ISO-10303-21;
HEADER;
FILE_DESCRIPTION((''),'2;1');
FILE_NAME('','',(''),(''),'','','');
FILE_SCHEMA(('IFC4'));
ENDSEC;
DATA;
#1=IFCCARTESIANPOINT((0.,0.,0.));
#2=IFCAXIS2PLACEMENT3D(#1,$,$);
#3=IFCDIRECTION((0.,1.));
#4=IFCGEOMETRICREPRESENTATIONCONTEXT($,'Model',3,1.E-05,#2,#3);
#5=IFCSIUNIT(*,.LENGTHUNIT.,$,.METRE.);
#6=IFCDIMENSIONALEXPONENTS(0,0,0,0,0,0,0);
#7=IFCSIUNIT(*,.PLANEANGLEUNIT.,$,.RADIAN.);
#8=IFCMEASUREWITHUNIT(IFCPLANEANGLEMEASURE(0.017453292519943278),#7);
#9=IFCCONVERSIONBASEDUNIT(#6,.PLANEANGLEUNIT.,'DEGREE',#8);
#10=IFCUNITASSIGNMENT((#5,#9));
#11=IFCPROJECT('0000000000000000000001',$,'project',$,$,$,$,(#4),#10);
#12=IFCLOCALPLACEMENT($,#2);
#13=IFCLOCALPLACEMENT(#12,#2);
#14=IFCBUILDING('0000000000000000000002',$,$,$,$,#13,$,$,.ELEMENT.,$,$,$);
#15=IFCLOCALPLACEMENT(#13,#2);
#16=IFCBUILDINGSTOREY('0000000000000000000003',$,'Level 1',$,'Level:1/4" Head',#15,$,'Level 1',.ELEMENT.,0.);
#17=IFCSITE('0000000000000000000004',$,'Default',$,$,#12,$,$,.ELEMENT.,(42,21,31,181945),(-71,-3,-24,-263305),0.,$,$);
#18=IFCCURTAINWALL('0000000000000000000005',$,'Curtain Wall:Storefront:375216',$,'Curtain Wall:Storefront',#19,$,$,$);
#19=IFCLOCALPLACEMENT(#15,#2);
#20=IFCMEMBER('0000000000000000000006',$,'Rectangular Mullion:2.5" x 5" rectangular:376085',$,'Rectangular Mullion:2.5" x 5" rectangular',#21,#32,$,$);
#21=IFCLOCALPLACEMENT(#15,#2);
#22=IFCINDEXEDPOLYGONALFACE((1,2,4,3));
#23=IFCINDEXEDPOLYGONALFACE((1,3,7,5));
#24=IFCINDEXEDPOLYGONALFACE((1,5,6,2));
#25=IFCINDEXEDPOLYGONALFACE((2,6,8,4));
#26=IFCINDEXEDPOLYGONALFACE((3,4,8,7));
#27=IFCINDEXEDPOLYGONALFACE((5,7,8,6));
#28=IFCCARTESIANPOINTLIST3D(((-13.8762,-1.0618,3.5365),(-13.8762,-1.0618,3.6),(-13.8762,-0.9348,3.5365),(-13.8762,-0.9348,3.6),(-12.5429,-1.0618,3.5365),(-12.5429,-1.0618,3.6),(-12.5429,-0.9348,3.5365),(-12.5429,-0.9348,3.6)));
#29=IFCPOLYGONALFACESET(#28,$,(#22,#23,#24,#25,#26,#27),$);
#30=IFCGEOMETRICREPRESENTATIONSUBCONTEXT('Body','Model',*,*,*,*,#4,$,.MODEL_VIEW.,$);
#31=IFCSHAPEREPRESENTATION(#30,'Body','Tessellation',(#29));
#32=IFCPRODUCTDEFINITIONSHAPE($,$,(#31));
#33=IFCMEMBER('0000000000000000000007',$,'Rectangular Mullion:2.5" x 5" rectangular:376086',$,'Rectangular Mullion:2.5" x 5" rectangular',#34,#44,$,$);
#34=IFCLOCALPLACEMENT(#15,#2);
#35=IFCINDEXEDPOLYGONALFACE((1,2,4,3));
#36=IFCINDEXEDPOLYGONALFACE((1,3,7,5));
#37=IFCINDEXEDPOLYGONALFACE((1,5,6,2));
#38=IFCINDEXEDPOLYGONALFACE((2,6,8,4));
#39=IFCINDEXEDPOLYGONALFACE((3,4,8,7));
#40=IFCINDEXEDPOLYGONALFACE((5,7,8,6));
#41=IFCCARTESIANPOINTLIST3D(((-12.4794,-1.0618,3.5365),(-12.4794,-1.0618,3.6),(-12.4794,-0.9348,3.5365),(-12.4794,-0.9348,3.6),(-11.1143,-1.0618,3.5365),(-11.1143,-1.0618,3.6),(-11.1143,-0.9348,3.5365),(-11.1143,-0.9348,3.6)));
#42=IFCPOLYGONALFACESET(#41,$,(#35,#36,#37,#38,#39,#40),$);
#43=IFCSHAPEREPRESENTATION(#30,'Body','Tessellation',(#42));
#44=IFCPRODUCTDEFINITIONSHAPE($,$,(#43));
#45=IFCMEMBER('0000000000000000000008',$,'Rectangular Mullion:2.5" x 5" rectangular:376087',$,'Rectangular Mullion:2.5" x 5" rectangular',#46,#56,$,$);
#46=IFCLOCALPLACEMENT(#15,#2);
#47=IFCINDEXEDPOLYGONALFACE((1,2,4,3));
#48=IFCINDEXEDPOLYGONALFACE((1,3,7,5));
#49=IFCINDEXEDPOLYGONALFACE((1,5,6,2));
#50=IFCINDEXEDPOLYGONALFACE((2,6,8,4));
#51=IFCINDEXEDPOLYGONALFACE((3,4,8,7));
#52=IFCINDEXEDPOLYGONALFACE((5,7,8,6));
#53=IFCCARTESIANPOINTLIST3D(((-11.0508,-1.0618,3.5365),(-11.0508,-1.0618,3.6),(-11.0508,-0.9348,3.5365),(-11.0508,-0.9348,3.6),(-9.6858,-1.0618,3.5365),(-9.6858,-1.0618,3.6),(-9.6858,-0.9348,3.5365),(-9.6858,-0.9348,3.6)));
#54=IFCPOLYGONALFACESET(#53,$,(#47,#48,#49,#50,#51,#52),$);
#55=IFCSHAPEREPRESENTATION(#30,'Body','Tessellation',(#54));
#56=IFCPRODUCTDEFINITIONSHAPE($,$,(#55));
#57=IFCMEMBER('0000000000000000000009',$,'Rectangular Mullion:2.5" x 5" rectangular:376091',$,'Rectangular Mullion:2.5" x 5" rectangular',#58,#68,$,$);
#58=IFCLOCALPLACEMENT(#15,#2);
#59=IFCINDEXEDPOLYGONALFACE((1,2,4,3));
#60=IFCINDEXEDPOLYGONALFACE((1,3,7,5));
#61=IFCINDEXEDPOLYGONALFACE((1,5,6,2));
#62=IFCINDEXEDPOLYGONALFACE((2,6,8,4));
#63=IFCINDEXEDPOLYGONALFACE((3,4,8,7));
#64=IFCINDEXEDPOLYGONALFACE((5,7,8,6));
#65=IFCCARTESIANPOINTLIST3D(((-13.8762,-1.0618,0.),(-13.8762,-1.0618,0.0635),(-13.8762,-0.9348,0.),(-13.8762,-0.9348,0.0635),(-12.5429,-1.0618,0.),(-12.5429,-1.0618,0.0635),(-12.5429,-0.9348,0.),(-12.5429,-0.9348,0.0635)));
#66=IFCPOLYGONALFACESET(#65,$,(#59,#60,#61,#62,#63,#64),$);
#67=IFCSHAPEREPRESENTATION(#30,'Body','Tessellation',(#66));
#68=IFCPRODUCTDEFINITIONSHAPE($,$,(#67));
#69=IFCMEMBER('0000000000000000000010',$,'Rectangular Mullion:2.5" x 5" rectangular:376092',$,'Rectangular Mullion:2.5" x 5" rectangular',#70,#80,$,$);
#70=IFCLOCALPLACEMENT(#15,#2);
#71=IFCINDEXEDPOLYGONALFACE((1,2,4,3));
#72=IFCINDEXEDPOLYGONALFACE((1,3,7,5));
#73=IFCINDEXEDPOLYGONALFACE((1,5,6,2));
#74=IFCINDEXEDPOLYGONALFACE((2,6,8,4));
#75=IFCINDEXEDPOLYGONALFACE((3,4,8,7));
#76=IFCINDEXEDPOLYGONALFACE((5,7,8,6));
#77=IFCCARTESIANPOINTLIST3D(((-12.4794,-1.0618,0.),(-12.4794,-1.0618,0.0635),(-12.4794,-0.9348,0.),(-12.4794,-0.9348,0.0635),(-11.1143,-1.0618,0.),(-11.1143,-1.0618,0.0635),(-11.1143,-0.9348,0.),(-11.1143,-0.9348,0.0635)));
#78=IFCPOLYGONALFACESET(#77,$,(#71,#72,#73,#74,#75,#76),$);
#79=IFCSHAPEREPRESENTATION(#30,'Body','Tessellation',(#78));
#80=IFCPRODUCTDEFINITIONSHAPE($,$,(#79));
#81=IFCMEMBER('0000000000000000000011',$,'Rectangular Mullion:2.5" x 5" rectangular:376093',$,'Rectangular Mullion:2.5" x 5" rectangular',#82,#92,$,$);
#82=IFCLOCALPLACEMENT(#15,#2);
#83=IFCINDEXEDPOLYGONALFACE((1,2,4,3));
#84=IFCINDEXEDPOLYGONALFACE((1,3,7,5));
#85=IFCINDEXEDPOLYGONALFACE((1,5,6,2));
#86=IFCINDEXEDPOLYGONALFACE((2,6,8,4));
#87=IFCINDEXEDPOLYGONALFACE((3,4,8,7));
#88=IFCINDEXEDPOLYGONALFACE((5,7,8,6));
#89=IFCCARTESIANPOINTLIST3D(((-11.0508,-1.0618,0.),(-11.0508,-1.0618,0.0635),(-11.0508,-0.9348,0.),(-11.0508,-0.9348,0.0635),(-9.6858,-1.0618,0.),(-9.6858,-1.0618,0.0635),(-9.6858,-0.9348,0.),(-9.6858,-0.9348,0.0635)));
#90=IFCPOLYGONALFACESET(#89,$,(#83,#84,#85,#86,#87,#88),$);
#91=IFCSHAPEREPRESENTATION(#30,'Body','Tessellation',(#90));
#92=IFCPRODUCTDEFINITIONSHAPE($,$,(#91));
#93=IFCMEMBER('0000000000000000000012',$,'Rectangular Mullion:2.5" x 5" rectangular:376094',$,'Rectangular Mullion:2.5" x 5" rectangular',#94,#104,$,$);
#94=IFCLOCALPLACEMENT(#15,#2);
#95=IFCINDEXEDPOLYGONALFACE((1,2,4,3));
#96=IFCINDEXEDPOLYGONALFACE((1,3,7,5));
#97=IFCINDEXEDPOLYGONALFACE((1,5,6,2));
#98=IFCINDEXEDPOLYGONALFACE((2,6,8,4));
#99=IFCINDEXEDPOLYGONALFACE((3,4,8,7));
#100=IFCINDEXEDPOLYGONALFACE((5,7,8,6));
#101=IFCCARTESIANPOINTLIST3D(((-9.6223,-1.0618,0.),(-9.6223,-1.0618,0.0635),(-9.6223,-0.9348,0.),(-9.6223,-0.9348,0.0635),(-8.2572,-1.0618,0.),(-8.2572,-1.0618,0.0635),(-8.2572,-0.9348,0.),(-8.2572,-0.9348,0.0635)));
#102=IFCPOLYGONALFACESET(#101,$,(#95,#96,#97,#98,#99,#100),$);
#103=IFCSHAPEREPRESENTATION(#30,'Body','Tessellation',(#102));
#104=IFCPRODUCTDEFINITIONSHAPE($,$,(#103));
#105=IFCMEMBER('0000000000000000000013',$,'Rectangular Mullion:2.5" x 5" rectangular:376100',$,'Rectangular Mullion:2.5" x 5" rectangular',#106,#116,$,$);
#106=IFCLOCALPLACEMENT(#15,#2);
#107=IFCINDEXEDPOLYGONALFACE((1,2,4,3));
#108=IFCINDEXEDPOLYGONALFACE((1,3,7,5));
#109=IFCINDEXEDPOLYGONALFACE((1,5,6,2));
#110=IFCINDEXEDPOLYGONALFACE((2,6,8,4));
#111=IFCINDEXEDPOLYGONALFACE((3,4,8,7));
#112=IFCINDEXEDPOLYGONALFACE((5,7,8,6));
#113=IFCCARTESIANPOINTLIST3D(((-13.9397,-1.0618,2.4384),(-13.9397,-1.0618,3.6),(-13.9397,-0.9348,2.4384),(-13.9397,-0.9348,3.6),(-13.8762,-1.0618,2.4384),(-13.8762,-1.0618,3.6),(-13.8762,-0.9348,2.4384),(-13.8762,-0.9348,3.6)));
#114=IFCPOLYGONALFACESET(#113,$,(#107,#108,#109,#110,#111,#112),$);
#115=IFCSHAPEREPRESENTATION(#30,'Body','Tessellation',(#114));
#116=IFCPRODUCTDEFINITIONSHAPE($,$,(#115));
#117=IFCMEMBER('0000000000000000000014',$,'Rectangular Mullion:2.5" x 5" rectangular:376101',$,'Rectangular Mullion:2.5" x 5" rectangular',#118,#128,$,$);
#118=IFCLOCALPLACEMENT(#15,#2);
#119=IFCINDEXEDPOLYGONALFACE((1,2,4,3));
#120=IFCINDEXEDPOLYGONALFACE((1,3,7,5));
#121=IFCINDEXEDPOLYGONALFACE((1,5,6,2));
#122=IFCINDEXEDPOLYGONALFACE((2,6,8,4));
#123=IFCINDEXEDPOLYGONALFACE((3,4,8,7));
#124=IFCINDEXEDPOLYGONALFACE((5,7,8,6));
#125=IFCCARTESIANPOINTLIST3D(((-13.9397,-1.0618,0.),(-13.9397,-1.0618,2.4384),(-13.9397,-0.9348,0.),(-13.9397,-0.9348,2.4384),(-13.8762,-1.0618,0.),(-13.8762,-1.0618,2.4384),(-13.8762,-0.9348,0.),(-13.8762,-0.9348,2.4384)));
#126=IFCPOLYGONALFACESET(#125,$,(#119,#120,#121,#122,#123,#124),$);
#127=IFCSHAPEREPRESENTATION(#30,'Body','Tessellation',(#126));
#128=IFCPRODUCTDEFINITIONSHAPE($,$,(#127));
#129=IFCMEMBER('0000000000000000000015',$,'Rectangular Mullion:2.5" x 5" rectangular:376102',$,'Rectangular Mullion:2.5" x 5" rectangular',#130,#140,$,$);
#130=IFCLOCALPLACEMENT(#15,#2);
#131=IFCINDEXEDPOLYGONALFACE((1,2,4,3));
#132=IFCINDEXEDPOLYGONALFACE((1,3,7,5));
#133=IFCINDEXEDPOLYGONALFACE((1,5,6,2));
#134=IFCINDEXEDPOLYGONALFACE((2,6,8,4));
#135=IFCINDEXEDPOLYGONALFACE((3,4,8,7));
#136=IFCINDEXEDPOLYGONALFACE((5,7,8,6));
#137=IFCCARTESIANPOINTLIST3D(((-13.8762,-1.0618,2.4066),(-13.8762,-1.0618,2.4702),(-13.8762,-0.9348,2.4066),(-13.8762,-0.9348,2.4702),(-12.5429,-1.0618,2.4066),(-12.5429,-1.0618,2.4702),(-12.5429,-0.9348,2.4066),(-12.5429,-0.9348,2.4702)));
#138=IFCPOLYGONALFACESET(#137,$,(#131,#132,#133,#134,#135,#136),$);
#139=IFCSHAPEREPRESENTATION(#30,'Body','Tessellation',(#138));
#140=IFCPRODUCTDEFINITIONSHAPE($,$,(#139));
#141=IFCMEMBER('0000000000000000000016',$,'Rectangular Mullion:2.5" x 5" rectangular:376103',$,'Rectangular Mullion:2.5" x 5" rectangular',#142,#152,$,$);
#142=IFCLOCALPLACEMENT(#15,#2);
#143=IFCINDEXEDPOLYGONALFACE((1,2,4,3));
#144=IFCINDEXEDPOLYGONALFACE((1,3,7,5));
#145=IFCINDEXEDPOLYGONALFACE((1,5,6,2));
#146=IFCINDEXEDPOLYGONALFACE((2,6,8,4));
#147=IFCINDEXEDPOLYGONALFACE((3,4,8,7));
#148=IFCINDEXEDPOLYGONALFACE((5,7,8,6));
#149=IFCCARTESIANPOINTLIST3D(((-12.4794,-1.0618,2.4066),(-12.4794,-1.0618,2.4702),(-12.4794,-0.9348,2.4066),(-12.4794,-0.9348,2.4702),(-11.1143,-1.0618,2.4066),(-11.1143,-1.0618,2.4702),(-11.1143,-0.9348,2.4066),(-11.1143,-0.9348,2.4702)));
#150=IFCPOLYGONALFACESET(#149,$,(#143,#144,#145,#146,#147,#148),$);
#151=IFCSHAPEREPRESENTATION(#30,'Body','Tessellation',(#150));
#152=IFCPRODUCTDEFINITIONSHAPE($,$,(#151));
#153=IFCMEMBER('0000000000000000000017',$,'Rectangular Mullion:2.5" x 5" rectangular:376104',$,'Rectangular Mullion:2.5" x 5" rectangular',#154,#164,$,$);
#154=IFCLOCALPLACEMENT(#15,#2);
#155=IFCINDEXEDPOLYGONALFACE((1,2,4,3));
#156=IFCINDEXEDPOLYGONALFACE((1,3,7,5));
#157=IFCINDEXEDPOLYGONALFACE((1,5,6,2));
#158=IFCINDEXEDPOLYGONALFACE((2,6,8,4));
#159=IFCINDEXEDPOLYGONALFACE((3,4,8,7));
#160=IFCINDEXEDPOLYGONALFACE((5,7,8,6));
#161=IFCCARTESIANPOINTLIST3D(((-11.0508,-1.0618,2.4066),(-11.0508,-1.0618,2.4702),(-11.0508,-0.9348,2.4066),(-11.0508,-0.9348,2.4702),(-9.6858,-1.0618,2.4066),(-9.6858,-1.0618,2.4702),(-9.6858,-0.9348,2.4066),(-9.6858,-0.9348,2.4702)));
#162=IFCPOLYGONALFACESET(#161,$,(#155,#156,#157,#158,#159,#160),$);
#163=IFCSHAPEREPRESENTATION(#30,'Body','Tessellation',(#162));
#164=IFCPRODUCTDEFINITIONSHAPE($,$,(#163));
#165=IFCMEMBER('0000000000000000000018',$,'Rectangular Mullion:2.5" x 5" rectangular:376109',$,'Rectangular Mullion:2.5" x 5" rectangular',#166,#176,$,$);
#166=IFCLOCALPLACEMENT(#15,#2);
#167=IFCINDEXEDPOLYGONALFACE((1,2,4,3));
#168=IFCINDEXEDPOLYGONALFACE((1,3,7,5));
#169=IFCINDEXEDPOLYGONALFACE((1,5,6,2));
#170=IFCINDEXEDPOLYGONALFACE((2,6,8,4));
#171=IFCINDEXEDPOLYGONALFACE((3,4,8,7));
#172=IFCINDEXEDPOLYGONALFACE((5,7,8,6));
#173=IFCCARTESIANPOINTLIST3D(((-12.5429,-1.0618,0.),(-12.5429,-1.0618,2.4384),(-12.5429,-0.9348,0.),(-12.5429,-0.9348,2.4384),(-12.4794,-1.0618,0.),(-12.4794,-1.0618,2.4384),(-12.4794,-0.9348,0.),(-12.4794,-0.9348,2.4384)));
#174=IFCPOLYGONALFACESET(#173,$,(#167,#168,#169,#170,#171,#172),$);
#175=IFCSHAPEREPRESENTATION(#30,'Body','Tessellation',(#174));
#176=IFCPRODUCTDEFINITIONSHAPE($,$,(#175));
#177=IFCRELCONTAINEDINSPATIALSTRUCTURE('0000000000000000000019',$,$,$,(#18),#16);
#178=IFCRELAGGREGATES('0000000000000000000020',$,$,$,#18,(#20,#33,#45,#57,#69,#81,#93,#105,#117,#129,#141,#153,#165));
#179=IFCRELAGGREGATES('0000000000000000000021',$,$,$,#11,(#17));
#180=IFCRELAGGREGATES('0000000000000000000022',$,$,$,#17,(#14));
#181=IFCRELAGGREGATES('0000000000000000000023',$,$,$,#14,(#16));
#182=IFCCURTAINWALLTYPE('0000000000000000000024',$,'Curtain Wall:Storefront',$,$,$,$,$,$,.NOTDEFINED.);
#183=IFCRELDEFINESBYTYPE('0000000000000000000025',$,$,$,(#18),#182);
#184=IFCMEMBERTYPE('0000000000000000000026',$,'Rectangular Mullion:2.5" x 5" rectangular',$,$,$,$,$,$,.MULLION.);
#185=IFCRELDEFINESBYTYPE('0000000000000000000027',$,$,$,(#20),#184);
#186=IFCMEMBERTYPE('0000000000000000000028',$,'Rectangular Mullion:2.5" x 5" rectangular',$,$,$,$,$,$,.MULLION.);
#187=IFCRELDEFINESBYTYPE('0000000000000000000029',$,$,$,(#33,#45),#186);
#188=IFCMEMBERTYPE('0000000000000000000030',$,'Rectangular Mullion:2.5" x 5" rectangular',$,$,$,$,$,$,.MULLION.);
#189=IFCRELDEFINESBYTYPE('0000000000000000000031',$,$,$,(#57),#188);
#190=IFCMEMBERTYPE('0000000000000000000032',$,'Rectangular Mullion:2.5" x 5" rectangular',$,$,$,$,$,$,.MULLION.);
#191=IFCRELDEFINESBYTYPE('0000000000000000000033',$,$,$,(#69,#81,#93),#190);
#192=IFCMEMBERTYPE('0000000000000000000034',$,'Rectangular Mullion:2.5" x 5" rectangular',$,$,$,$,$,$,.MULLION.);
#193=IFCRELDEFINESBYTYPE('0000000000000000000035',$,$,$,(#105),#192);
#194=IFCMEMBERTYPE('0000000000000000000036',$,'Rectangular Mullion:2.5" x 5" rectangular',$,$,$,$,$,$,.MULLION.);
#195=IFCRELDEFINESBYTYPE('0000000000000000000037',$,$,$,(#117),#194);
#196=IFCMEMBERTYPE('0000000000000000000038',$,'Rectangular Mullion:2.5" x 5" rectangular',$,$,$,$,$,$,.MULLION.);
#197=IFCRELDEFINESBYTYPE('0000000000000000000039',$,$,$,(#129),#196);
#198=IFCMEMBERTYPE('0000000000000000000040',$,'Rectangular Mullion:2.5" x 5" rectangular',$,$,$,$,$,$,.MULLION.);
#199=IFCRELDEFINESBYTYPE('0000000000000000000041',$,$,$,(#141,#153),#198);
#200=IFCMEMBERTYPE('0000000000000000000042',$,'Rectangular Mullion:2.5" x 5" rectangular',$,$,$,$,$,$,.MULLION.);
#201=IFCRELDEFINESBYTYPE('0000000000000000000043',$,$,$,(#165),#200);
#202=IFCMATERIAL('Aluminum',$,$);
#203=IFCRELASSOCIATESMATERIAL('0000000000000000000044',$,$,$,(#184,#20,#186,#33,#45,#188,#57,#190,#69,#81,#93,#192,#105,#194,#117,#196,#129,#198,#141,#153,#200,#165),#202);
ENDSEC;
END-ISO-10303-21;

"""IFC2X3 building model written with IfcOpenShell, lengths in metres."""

from ifc_helpers import new_model, entity, si_unit, converted_unit, direction, frame, frame_2d, origin, origin_2d_with_axis, place, context, subcontext, project, spatial, rectangle, extrude, source, transform, mapped, material, type_object, type_shapes, element, aggregate, save


model = new_model("IFC2X3")

# Units and contexts
model_context = context("Model", 3, precision=1e-05, world=origin(), true_north=direction((0.0, 1.0)))
body_context = subcontext(model_context, "Body", "Model", "MODEL_VIEW")
ifc_project = project(units=[si_unit("LENGTHUNIT", "METRE"), converted_unit("PLANEANGLEUNIT", "DEGREE", entity("IfcPlaneAngleMeasure", 0.017453292519943278), si_unit("PLANEANGLEUNIT", "RADIAN"), dimensions=[0, 0, 0, 0, 0, 0, 0])], contexts=[model_context])

# Site, building, storey
site_placement = place(None, origin())
site = spatial("IfcSite", under=ifc_project, at=site_placement, Name="Default", CompositionType="ELEMENT", RefLatitude=(42, 21, 31, 181945), RefLongitude=(-71, -3, -24, -263305), RefElevation=0.0)
building_placement = place(site_placement, origin())
building = spatial("IfcBuilding", under=site, at=building_placement, CompositionType="ELEMENT")
storey_placement = place(building_placement, origin())
storey = spatial("IfcBuildingStorey", under=building, at=storey_placement, Name="Level 1", ObjectType="Level:1/4\" Head", LongName="Level 1", CompositionType="ELEMENT", Elevation=0.0)

# Curtain wall, members
curtain_wall_type = type_object("IfcCurtainWallType", Name="Curtain Wall:Storefront", PredefinedType="NOTDEFINED")
curtain_wall_placement = place(storey_placement, origin())
curtain_wall = element("IfcCurtainWall", 1, at=curtain_wall_placement, inside=storey, type_object=curtain_wall_type, Name="Curtain Wall:Storefront:375216", ObjectType="Curtain Wall:Storefront")
ifc_material_1 = material(Name="Aluminum")
member_type_1 = type_object("IfcMemberType", Name="Rectangular Mullion:2.5\" x 5\" rectangular", PredefinedType="MULLION", material=ifc_material_1)
shared_shape_1 = source(origin(), body_context, "Body", "SweptSolid", [
    extrude(rectangle(XDim=0.0635, YDim=0.127, at=frame_2d((0.0, 0.0), x_axis=(1.0, 0.0))), frame((-0.0318, 0.0, -1.3333), z_axis=(0.0, 0.0, 1.0), x_axis=(-1.0, 0.0, 0.0)), (0.0, 0.0, 1.0), 1.3333),
])
type_shapes(member_type_1, [shared_shape_1])
member_1_placement = place(curtain_wall_placement, frame((-12.5429, -0.9983, 3.6), z_axis=(1.0, 0.0, 0.0), x_axis=(0.0, 0.0, 1.0)))
member_1 = element("IfcMember", 2, at=member_1_placement, type_object=member_type_1, material=ifc_material_1, Name="Rectangular Mullion:2.5\" x 5\" rectangular:376085", ObjectType="Rectangular Mullion:2.5\" x 5\" rectangular", context=body_context, shape_type="MappedRepresentation", body=[
    mapped(shared_shape_1, transform((0.0, 0.0, 0.0), scale=1.0)),
])
member_type_2 = type_object("IfcMemberType", Name="Rectangular Mullion:2.5\" x 5\" rectangular", PredefinedType="MULLION", material=ifc_material_1)
shared_shape_2 = source(origin(), body_context, "Body", "SweptSolid", [
    extrude(rectangle(XDim=0.0635, YDim=0.127, at=frame_2d((0.0, 0.0), x_axis=(1.0, 0.0))), frame((-0.0318, 0.0, -1.3651), z_axis=(0.0, 0.0, 1.0), x_axis=(-1.0, 0.0, 0.0)), (0.0, 0.0, 1.0), 1.3651),
])
type_shapes(member_type_2, [shared_shape_2])
member_2_placement = place(curtain_wall_placement, frame((-11.1143, -0.9983, 3.6), z_axis=(1.0, 0.0, 0.0), x_axis=(0.0, 0.0, 1.0)))
member_2 = element("IfcMember", 3, at=member_2_placement, type_object=member_type_2, material=ifc_material_1, Name="Rectangular Mullion:2.5\" x 5\" rectangular:376086", ObjectType="Rectangular Mullion:2.5\" x 5\" rectangular", context=body_context, shape_type="MappedRepresentation", body=[
    mapped(shared_shape_2, transform((0.0, 0.0, 0.0), scale=1.0)),
])
member_3_placement = place(curtain_wall_placement, frame((-9.6858, -0.9983, 3.6), z_axis=(1.0, 0.0, 0.0), x_axis=(0.0, 0.0, 1.0)))
member_3 = element("IfcMember", 4, at=member_3_placement, type_object=member_type_2, material=ifc_material_1, Name="Rectangular Mullion:2.5\" x 5\" rectangular:376087", ObjectType="Rectangular Mullion:2.5\" x 5\" rectangular", context=body_context, shape_type="MappedRepresentation", body=[
    mapped(shared_shape_2, transform((0.0, 0.0, 0.0), scale=1.0)),
])
member_type_3 = type_object("IfcMemberType", Name="Rectangular Mullion:2.5\" x 5\" rectangular", PredefinedType="MULLION", material=ifc_material_1)
shared_shape_3 = source(origin(), body_context, "Body", "SweptSolid", [
    extrude(rectangle(XDim=0.0635, YDim=0.127, at=frame_2d((0.0, 0.0), x_axis=(1.0, 0.0))), frame((-0.0318, 0.0, -1.3333), z_axis=(0.0, 0.0, 1.0), x_axis=(-1.0, 0.0, 0.0)), (0.0, 0.0, 1.0), 1.3333),
])
type_shapes(member_type_3, [shared_shape_3])
member_4_placement = place(curtain_wall_placement, frame((-13.8762, -0.9983, 0.0), z_axis=(-1.0, 0.0, 0.0), x_axis=(0.0, 0.0, -1.0)))
member_4 = element("IfcMember", 5, at=member_4_placement, type_object=member_type_3, material=ifc_material_1, Name="Rectangular Mullion:2.5\" x 5\" rectangular:376091", ObjectType="Rectangular Mullion:2.5\" x 5\" rectangular", context=body_context, shape_type="MappedRepresentation", body=[
    mapped(shared_shape_3, transform((0.0, 0.0, 0.0), scale=1.0)),
])
member_type_4 = type_object("IfcMemberType", Name="Rectangular Mullion:2.5\" x 5\" rectangular", PredefinedType="MULLION", material=ifc_material_1)
shared_shape_4 = source(origin(), body_context, "Body", "SweptSolid", [
    extrude(rectangle(XDim=0.0635, YDim=0.127, at=frame_2d((0.0, 0.0), x_axis=(1.0, 0.0))), frame((-0.0318, 0.0, -1.3651), z_axis=(0.0, 0.0, 1.0), x_axis=(-1.0, 0.0, 0.0)), (0.0, 0.0, 1.0), 1.3651),
])
type_shapes(member_type_4, [shared_shape_4])
member_5_placement = place(curtain_wall_placement, frame((-12.4794, -0.9983, 0.0), z_axis=(-1.0, 0.0, 0.0), x_axis=(0.0, 0.0, -1.0)))
member_5 = element("IfcMember", 6, at=member_5_placement, type_object=member_type_4, material=ifc_material_1, Name="Rectangular Mullion:2.5\" x 5\" rectangular:376092", ObjectType="Rectangular Mullion:2.5\" x 5\" rectangular", context=body_context, shape_type="MappedRepresentation", body=[
    mapped(shared_shape_4, transform((0.0, 0.0, 0.0), scale=1.0)),
])
member_6_placement = place(curtain_wall_placement, frame((-11.0508, -0.9983, 0.0), z_axis=(-1.0, 0.0, 0.0), x_axis=(0.0, 0.0, -1.0)))
member_6 = element("IfcMember", 7, at=member_6_placement, type_object=member_type_4, material=ifc_material_1, Name="Rectangular Mullion:2.5\" x 5\" rectangular:376093", ObjectType="Rectangular Mullion:2.5\" x 5\" rectangular", context=body_context, shape_type="MappedRepresentation", body=[
    mapped(shared_shape_4, transform((0.0, 0.0, 0.0), scale=1.0)),
])
member_7_placement = place(curtain_wall_placement, frame((-9.6223, -0.9983, 0.0), z_axis=(-1.0, 0.0, 0.0), x_axis=(0.0, 0.0, -1.0)))
member_7 = element("IfcMember", 8, at=member_7_placement, type_object=member_type_4, material=ifc_material_1, Name="Rectangular Mullion:2.5\" x 5\" rectangular:376094", ObjectType="Rectangular Mullion:2.5\" x 5\" rectangular", context=body_context, shape_type="MappedRepresentation", body=[
    mapped(shared_shape_4, transform((0.0, 0.0, 0.0), scale=1.0)),
])
member_type_5 = type_object("IfcMemberType", Name="Rectangular Mullion:2.5\" x 5\" rectangular", PredefinedType="MULLION", material=ifc_material_1)
shared_shape_5 = source(origin(), body_context, "Body", "SweptSolid", [
    extrude(rectangle(XDim=0.0635, YDim=0.127, at=frame_2d((0.0, 0.0), x_axis=(1.0, 0.0))), frame((-0.0318, 0.0, -1.1616), z_axis=(0.0, 0.0, 1.0), x_axis=(-1.0, 0.0, 0.0)), (0.0, 0.0, 1.0), 1.1616),
])
type_shapes(member_type_5, [shared_shape_5])
member_8_placement = place(curtain_wall_placement, frame((-13.9397, -0.9983, 3.6), z_axis=(0.0, 0.0, 1.0), x_axis=(-1.0, 0.0, 0.0)))
member_8 = element("IfcMember", 9, at=member_8_placement, type_object=member_type_5, material=ifc_material_1, Name="Rectangular Mullion:2.5\" x 5\" rectangular:376100", ObjectType="Rectangular Mullion:2.5\" x 5\" rectangular", context=body_context, shape_type="MappedRepresentation", body=[
    mapped(shared_shape_5, transform((0.0, 0.0, 0.0), scale=1.0)),
])
member_type_6 = type_object("IfcMemberType", Name="Rectangular Mullion:2.5\" x 5\" rectangular", PredefinedType="MULLION", material=ifc_material_1)
shared_shape_6 = source(origin(), body_context, "Body", "SweptSolid", [
    extrude(rectangle(XDim=0.0635, YDim=0.127, at=frame_2d((0.0, 0.0), x_axis=(1.0, 0.0))), frame((-0.0318, 0.0, -2.4384), z_axis=(0.0, 0.0, 1.0), x_axis=(-1.0, 0.0, 0.0)), (0.0, 0.0, 1.0), 2.4384),
])
type_shapes(member_type_6, [shared_shape_6])
member_9_placement = place(curtain_wall_placement, frame((-13.9397, -0.9983, 2.4384), z_axis=(0.0, 0.0, 1.0), x_axis=(-1.0, 0.0, 0.0)))
member_9 = element("IfcMember", 10, at=member_9_placement, type_object=member_type_6, material=ifc_material_1, Name="Rectangular Mullion:2.5\" x 5\" rectangular:376101", ObjectType="Rectangular Mullion:2.5\" x 5\" rectangular", context=body_context, shape_type="MappedRepresentation", body=[
    mapped(shared_shape_6, transform((0.0, 0.0, 0.0), scale=1.0)),
])
member_type_7 = type_object("IfcMemberType", Name="Rectangular Mullion:2.5\" x 5\" rectangular", PredefinedType="MULLION", material=ifc_material_1)
shared_shape_7 = source(origin(), body_context, "Body", "SweptSolid", [
    extrude(rectangle(XDim=0.0635, YDim=0.127, at=origin_2d_with_axis()), frame((0.0, 0.0, -1.3333), z_axis=(0.0, 0.0, 1.0), x_axis=(-1.0, 0.0, 0.0)), (0.0, 0.0, 1.0), 1.3333),
])
type_shapes(member_type_7, [shared_shape_7])
member_10_placement = place(curtain_wall_placement, frame((-12.5429, -0.9983, 2.4384), z_axis=(1.0, 0.0, 0.0), x_axis=(0.0, 0.0, 1.0)))
member_10 = element("IfcMember", 11, at=member_10_placement, type_object=member_type_7, material=ifc_material_1, Name="Rectangular Mullion:2.5\" x 5\" rectangular:376102", ObjectType="Rectangular Mullion:2.5\" x 5\" rectangular", context=body_context, shape_type="MappedRepresentation", body=[
    mapped(shared_shape_7, transform((0.0, 0.0, 0.0), scale=1.0)),
])
member_type_8 = type_object("IfcMemberType", Name="Rectangular Mullion:2.5\" x 5\" rectangular", PredefinedType="MULLION", material=ifc_material_1)
shared_shape_8 = source(origin(), body_context, "Body", "SweptSolid", [
    extrude(rectangle(XDim=0.0635, YDim=0.127, at=origin_2d_with_axis()), frame((0.0, 0.0, -1.3651), z_axis=(0.0, 0.0, 1.0), x_axis=(-1.0, 0.0, 0.0)), (0.0, 0.0, 1.0), 1.3651),
])
type_shapes(member_type_8, [shared_shape_8])
member_11_placement = place(curtain_wall_placement, frame((-11.1143, -0.9983, 2.4384), z_axis=(1.0, 0.0, 0.0), x_axis=(0.0, 0.0, 1.0)))
member_11 = element("IfcMember", 12, at=member_11_placement, type_object=member_type_8, material=ifc_material_1, Name="Rectangular Mullion:2.5\" x 5\" rectangular:376103", ObjectType="Rectangular Mullion:2.5\" x 5\" rectangular", context=body_context, shape_type="MappedRepresentation", body=[
    mapped(shared_shape_8, transform((0.0, 0.0, 0.0), scale=1.0)),
])
member_12_placement = place(curtain_wall_placement, frame((-9.6858, -0.9983, 2.4384), z_axis=(1.0, 0.0, 0.0), x_axis=(0.0, 0.0, 1.0)))
member_12 = element("IfcMember", 13, at=member_12_placement, type_object=member_type_8, material=ifc_material_1, Name="Rectangular Mullion:2.5\" x 5\" rectangular:376104", ObjectType="Rectangular Mullion:2.5\" x 5\" rectangular", context=body_context, shape_type="MappedRepresentation", body=[
    mapped(shared_shape_8, transform((0.0, 0.0, 0.0), scale=1.0)),
])
member_type_9 = type_object("IfcMemberType", Name="Rectangular Mullion:2.5\" x 5\" rectangular", PredefinedType="MULLION", material=ifc_material_1)
shared_shape_9 = source(origin(), body_context, "Body", "SweptSolid", [
    extrude(rectangle(XDim=0.0635, YDim=0.127, at=origin_2d_with_axis()), frame((0.0, 0.0, -2.4384), z_axis=(0.0, 0.0, 1.0), x_axis=(-1.0, 0.0, 0.0)), (0.0, 0.0, 1.0), 2.4384),
])
type_shapes(member_type_9, [shared_shape_9])
member_13_placement = place(curtain_wall_placement, frame((-12.5112, -0.9983, 0.0), z_axis=(0.0, 0.0, -1.0), x_axis=(1.0, 0.0, 0.0)))
member_13 = element("IfcMember", 14, at=member_13_placement, type_object=member_type_9, material=ifc_material_1, Name="Rectangular Mullion:2.5\" x 5\" rectangular:376109", ObjectType="Rectangular Mullion:2.5\" x 5\" rectangular", context=body_context, shape_type="MappedRepresentation", body=[
    mapped(shared_shape_9, transform((0.0, 0.0, 0.0), scale=1.0)),
])
aggregate(curtain_wall, [member_1, member_2, member_3, member_4, member_5, member_6, member_7, member_8, member_9, member_10, member_11, member_12, member_13])

save(model, "model.ifc")
